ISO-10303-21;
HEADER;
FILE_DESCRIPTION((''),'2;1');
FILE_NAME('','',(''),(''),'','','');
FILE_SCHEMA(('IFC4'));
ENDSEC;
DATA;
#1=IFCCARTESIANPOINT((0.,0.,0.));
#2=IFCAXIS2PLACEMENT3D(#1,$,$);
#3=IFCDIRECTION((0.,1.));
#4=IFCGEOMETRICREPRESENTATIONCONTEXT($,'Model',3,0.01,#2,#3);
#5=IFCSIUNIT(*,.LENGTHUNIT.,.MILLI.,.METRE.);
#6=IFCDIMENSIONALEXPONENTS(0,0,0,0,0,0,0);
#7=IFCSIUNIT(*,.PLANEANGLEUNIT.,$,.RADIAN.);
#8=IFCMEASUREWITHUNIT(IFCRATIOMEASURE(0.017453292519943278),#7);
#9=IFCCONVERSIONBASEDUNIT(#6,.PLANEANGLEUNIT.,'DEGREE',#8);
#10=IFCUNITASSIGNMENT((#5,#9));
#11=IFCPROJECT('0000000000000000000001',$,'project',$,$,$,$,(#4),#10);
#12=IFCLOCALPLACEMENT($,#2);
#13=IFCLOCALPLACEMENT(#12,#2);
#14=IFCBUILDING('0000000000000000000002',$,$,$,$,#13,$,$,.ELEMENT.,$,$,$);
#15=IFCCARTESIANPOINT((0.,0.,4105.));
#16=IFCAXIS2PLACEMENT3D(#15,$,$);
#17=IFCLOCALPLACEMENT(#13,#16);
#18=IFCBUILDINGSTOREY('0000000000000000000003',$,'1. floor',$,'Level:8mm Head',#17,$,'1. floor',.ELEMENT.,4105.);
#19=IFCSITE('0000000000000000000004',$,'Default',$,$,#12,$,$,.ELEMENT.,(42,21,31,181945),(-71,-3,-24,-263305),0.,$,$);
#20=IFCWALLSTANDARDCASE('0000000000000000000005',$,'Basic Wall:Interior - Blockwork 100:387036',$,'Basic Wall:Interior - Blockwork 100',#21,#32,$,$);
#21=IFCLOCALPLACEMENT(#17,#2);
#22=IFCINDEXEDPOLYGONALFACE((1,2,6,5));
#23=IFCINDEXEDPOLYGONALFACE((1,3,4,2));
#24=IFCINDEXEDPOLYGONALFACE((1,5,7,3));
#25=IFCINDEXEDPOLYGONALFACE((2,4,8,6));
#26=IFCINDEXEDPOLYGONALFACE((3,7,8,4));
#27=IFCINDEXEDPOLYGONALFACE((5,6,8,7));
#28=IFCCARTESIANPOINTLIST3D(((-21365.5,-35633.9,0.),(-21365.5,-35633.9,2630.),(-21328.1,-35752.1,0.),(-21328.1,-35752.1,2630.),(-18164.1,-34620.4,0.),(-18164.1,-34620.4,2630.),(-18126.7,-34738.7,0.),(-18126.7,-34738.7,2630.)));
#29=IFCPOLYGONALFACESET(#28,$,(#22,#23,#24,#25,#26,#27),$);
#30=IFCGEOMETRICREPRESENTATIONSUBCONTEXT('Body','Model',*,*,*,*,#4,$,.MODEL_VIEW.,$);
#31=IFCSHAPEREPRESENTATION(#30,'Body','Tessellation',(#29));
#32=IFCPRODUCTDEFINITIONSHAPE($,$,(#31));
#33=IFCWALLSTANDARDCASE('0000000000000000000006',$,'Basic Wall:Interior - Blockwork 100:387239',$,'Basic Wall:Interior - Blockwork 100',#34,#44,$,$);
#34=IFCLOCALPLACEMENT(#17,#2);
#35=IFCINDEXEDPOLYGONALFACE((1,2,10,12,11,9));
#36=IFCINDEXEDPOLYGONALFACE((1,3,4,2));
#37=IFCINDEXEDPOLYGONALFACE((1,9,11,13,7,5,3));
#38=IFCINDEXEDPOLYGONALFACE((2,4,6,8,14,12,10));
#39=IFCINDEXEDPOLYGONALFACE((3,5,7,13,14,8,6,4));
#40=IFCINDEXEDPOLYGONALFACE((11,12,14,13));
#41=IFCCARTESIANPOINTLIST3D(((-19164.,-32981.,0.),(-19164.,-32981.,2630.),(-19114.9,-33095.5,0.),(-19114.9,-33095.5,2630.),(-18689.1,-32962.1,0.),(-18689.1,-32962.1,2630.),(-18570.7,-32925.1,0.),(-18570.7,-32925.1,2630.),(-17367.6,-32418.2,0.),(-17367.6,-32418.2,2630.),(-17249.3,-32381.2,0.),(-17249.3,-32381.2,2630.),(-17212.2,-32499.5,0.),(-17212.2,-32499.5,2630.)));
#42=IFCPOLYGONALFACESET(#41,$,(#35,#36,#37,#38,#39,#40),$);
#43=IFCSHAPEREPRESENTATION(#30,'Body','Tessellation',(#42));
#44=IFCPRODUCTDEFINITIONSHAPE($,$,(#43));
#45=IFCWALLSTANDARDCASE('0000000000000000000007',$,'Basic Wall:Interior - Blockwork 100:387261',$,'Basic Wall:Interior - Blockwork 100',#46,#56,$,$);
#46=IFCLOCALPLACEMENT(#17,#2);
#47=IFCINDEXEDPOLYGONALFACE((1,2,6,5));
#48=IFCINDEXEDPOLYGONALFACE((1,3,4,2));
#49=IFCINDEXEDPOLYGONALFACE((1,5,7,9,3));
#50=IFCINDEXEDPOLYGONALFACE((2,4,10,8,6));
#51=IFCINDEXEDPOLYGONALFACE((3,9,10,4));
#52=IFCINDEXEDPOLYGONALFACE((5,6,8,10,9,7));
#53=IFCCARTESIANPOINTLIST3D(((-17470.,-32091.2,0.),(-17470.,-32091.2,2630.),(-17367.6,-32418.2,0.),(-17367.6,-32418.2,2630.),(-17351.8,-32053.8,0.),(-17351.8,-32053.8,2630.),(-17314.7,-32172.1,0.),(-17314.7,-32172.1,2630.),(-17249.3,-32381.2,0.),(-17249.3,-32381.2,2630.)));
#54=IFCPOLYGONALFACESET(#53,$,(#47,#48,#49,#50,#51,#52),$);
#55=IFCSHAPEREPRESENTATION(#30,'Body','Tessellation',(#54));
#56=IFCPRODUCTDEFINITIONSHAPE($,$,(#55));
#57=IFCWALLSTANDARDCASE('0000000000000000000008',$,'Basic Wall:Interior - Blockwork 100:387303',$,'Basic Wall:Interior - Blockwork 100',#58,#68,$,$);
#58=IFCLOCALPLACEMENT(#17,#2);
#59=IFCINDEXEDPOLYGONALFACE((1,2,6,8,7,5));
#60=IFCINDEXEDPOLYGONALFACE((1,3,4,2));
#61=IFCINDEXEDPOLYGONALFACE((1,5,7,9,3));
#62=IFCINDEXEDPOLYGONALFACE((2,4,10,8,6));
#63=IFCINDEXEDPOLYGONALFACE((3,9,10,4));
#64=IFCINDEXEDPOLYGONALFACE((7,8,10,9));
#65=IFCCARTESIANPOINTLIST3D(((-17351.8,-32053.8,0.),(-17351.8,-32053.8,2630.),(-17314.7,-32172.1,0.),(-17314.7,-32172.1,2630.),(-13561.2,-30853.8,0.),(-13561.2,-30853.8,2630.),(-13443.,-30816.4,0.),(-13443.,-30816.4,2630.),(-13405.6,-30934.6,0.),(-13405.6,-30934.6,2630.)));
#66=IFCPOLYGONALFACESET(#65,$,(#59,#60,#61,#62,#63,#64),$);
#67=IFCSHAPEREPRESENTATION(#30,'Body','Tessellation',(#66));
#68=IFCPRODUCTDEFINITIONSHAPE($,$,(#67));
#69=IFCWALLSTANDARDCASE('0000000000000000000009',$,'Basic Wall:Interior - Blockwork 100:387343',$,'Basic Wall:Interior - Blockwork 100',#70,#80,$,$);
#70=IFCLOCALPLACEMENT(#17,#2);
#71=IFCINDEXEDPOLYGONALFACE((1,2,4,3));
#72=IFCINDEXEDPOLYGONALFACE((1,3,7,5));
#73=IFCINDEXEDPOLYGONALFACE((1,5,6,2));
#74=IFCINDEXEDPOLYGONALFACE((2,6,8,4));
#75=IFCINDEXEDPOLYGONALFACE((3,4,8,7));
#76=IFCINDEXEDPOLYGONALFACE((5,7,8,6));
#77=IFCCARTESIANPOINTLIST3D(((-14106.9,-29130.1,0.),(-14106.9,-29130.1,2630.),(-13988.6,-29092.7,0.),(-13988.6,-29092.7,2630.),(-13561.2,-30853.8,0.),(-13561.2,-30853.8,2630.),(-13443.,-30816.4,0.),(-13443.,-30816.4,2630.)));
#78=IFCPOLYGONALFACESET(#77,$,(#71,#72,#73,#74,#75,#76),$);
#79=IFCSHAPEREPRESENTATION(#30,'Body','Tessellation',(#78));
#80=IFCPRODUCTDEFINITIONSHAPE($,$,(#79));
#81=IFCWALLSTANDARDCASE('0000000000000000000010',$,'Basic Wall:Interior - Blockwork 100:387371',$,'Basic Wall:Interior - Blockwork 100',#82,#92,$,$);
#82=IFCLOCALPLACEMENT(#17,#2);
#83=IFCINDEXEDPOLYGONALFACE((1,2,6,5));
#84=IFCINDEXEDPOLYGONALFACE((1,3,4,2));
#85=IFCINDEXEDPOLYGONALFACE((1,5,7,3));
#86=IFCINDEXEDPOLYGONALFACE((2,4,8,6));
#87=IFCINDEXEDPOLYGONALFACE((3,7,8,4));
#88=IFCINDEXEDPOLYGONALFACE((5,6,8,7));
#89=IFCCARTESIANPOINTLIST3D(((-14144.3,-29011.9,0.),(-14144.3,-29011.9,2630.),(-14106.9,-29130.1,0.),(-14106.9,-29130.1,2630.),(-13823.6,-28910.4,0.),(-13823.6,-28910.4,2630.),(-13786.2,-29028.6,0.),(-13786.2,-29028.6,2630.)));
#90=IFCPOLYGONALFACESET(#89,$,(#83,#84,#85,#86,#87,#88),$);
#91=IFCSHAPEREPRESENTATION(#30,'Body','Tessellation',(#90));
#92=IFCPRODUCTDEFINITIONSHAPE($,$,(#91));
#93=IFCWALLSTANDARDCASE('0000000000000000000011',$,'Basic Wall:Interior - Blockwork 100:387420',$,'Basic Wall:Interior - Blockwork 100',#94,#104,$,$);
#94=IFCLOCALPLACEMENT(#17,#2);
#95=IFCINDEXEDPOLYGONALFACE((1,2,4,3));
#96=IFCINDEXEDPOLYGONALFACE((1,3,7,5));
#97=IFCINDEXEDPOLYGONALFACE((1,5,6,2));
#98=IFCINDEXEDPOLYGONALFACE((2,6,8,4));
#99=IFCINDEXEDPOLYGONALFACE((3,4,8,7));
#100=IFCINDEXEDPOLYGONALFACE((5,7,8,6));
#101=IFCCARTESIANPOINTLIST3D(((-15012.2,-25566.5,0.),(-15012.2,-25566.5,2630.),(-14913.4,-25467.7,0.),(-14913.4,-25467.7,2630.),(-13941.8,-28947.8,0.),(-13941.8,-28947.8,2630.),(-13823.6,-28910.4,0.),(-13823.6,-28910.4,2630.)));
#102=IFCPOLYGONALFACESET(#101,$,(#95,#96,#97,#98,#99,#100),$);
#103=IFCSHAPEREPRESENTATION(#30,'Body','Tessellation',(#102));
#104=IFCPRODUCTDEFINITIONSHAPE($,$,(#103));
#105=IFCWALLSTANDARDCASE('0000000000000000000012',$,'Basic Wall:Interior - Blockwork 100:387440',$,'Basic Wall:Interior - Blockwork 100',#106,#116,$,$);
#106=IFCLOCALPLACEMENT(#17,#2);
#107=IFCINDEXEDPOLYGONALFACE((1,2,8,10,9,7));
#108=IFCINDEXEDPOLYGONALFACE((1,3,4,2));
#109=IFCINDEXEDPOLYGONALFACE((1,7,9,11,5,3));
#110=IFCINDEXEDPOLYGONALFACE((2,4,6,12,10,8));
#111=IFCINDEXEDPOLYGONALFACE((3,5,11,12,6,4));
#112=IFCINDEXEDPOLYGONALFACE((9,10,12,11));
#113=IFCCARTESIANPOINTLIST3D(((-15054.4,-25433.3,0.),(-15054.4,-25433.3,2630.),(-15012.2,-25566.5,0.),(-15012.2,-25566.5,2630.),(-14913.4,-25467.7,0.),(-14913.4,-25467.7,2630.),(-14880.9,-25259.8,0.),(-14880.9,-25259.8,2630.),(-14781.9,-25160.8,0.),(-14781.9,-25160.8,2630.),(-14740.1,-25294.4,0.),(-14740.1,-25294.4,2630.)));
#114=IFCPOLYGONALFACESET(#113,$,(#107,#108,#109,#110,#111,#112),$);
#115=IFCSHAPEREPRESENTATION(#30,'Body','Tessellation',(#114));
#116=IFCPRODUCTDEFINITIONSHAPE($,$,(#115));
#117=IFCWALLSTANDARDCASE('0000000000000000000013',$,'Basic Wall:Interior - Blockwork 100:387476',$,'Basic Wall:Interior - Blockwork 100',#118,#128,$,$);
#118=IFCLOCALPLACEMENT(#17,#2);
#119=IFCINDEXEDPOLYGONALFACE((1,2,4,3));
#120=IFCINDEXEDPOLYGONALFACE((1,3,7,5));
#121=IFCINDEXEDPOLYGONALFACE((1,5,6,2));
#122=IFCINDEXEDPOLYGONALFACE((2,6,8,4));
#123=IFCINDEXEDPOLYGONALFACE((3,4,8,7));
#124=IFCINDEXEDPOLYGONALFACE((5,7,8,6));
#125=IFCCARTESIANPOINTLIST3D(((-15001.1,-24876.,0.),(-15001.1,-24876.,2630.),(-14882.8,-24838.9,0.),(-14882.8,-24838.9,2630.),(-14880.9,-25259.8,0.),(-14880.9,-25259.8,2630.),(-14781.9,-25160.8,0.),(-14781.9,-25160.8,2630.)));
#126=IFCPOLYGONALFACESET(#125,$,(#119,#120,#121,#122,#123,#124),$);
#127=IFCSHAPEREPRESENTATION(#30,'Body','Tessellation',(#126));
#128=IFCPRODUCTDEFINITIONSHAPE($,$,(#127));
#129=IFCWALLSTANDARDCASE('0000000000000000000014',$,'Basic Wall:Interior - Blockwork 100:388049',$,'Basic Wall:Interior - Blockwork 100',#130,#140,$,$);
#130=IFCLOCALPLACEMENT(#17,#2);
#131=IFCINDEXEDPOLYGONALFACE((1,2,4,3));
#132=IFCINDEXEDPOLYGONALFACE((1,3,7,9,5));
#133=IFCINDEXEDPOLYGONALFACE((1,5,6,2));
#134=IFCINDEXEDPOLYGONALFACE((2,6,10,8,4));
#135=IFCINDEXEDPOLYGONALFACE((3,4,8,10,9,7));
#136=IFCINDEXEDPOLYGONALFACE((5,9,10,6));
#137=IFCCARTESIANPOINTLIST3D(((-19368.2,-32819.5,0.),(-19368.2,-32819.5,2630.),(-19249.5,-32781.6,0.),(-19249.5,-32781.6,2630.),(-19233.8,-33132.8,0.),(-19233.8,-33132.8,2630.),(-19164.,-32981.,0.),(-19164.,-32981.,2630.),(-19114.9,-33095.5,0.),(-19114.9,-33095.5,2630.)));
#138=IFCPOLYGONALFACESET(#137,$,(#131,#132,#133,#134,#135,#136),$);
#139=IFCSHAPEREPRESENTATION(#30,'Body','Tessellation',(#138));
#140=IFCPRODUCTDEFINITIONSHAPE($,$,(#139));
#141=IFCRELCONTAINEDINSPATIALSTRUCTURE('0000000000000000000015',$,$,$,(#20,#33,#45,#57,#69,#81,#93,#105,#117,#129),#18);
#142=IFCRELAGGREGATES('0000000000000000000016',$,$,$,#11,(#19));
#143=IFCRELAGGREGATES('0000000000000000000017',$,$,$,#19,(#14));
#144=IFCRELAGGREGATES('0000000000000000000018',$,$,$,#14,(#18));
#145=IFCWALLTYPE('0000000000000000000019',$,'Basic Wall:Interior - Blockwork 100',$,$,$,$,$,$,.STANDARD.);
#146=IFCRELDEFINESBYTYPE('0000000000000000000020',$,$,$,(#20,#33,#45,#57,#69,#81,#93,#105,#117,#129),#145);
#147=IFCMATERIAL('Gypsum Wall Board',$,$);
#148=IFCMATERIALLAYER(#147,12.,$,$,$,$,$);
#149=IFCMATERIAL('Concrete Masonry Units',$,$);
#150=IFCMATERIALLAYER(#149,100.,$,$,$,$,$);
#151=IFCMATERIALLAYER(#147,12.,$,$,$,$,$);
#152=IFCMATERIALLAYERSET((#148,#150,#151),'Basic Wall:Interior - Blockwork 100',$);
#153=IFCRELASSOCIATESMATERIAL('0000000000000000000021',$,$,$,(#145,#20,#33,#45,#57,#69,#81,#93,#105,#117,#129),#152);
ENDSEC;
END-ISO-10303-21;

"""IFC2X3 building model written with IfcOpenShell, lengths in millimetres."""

from ifc_helpers import new_model, entity, si_unit, converted_unit, direction, frame, frame_2d, origin, place, context, subcontext, project, spatial, polyline, rectangle, outline, extrude, material, layer, layer_set, layer_usage, type_object, element, save


model = new_model("IFC2X3")

# Units and contexts
model_context = context("Model", 3, precision=0.01, world=origin(), true_north=direction((0.0, 1.0)))
body_context = subcontext(model_context, "Body", "Model", "MODEL_VIEW")
ifc_project = project(units=[si_unit("LENGTHUNIT", "METRE", prefix="MILLI"), converted_unit("PLANEANGLEUNIT", "DEGREE", entity("IfcRatioMeasure", 0.017453292519943278), si_unit("PLANEANGLEUNIT", "RADIAN"), dimensions=[0, 0, 0, 0, 0, 0, 0])], contexts=[model_context])

# Site, building, storey
site_placement = place(None, origin())
site = spatial("IfcSite", under=ifc_project, at=site_placement, Name="Default", CompositionType="ELEMENT", RefLatitude=(42, 21, 31, 181945), RefLongitude=(-71, -3, -24, -263305), RefElevation=0.0)
building_placement = place(site_placement, origin())
building = spatial("IfcBuilding", under=site, at=building_placement, CompositionType="ELEMENT")
storey_placement = place(building_placement, frame((0.0, 0.0, 4105.0)))
storey = spatial("IfcBuildingStorey", under=building, at=storey_placement, Name="1. floor", ObjectType="Level:8mm Head", LongName="1. floor", CompositionType="ELEMENT", Elevation=4105.0)

# Shared definitions
ifc_material_1 = material(Name="Gypsum Wall Board")

# Walls
ifc_layer_1 = layer(ifc_material_1, 12.0)
ifc_material_2 = material(Name="Concrete Masonry Units")
ifc_layer_2 = layer(ifc_material_2, 100.0)
ifc_layer_3 = layer(ifc_material_1, 12.0)
ifc_layer_set_1 = layer_set([ifc_layer_1, ifc_layer_2, ifc_layer_3], Name="Basic Wall:Interior - Blockwork 100")
wall_type_1 = type_object("IfcWallType", Name="Basic Wall:Interior - Blockwork 100", PredefinedType="STANDARD", material=ifc_layer_set_1)
ifc_layer_usage_1 = layer_usage(ifc_layer_set_1, "AXIS2", "NEGATIVE", 62.0)
wall_1_placement = place(storey_placement, frame((-18145.4, -34679.6, 0.0), z_axis=(0.0, 0.0, 1.0), x_axis=(-0.953372, -0.301797, 0.0)))
element("IfcWallStandardCase", 1, at=wall_1_placement, inside=storey, type_object=wall_type_1, material=ifc_layer_usage_1, Name="Basic Wall:Interior - Blockwork 100:387036", ObjectType="Basic Wall:Interior - Blockwork 100", context=body_context, shape_type="SweptSolid", body=[
    extrude(rectangle(XDim=3358.0, YDim=124.0, at=frame_2d((1679.0, 0.0), x_axis=(-1.0, 0.0))), origin(), (0.0, 0.0, 1.0), 2630.0),
])
ifc_layer_usage_2 = layer_usage(ifc_layer_set_1, "AXIS2", "NEGATIVE", 62.0)
wall_2_placement = place(storey_placement, frame((-19145.5, -33040.1, 0.0), z_axis=(0.0, 0.0, 1.0), x_axis=(0.954277, 0.298924, 0.0)))
element("IfcWallStandardCase", 2, at=wall_2_placement, inside=storey, type_object=wall_type_1, material=ifc_layer_usage_2, Name="Basic Wall:Interior - Blockwork 100:387239", ObjectType="Basic Wall:Interior - Blockwork 100", context=body_context, shape_type="SweptSolid", body=[
    extrude(outline(polyline([(2006.5, -62.0), (2006.5, 62.0), (1882.5, 62.0), (0.0, 62.0), (12.6, -62.0), (458.9, -62.0), (582.9, -62.0), (2006.5, -62.0)])), origin(), (0.0, 0.0, 1.0), 2630.0),
])
ifc_layer_usage_3 = layer_usage(ifc_layer_set_1, "AXIS2", "NEGATIVE", 62.0)
wall_3_placement = place(storey_placement, frame((-17308.4, -32399.7, 0.0), z_axis=(0.0, 0.0, 1.0), x_axis=(-0.298924, 0.954277, 0.0)))
element("IfcWallStandardCase", 3, at=wall_3_placement, inside=storey, type_object=wall_type_1, material=ifc_layer_usage_3, Name="Basic Wall:Interior - Blockwork 100:387261", ObjectType="Basic Wall:Interior - Blockwork 100", context=body_context, shape_type="SweptSolid", body=[
    extrude(outline(polyline([(343.1, -62.0), (342.7, 62.0), (0.0, 62.0), (0.0, -62.0), (219.1, -62.0), (343.1, -62.0)])), origin(), (0.0, 0.0, 1.0), 2630.0),
])
ifc_layer_usage_4 = layer_usage(ifc_layer_set_1, "AXIS2", "NEGATIVE", 62.0)
wall_4_placement = place(storey_placement, frame((-17333.5, -32113.0, 0.0), z_axis=(0.0, 0.0, 1.0), x_axis=(0.953372, 0.301797, 0.0)))
element("IfcWallStandardCase", 4, at=wall_4_placement, inside=storey, type_object=wall_type_1, material=ifc_layer_usage_4, Name="Basic Wall:Interior - Blockwork 100:387303", ObjectType="Basic Wall:Interior - Blockwork 100", context=body_context, shape_type="SweptSolid", body=[
    extrude(outline(polyline([(4100.4, -62.0), (4100.4, 62.0), (3976.4, 62.0), (0.4, 62.0), (0.0, -62.0), (4100.4, -62.0)])), origin(), (0.0, 0.0, 1.0), 2630.0),
])
ifc_layer_usage_5 = layer_usage(ifc_layer_set_1, "AXIS2", "NEGATIVE", 62.0)
wall_5_placement = place(storey_placement, frame((-13502.1, -30835.1, 0.0), z_axis=(0.0, 0.0, 1.0), x_axis=(-0.301797, 0.953372, 0.0)))
element("IfcWallStandardCase", 5, at=wall_5_placement, inside=storey, type_object=wall_type_1, material=ifc_layer_usage_5, Name="Basic Wall:Interior - Blockwork 100:387343", ObjectType="Basic Wall:Interior - Blockwork 100", context=body_context, shape_type="SweptSolid", body=[
    extrude(rectangle(XDim=1808.0, YDim=124.0, at=frame_2d((904.0, 0.0), x_axis=(-1.0, 0.0))), origin(), (0.0, 0.0, 1.0), 2630.0),
])
ifc_layer_usage_6 = layer_usage(ifc_layer_set_1, "AXIS2", "NEGATIVE", 62.0)
wall_6_placement = place(storey_placement, frame((-14125.6, -29071.0, 0.0), z_axis=(0.0, 0.0, 1.0), x_axis=(0.953372, 0.301797, 0.0)))
element("IfcWallStandardCase", 6, at=wall_6_placement, inside=storey, type_object=wall_type_1, material=ifc_layer_usage_6, Name="Basic Wall:Interior - Blockwork 100:387371", ObjectType="Basic Wall:Interior - Blockwork 100", context=body_context, shape_type="SweptSolid", body=[
    extrude(rectangle(XDim=336.4, YDim=124.0, at=frame_2d((168.2, 0.0), x_axis=(-1.0, 0.0))), origin(), (0.0, 0.0, 1.0), 2630.0),
])
ifc_layer_usage_7 = layer_usage(ifc_layer_set_1, "AXIS2", "NEGATIVE", 62.0)
wall_7_placement = place(storey_placement, frame((-13882.7, -28929.1, 0.0), z_axis=(0.0, 0.0, 1.0), x_axis=(-0.301797, 0.953372, 0.0)))
element("IfcWallStandardCase", 7, at=wall_7_placement, inside=storey, type_object=wall_type_1, material=ifc_layer_usage_7, Name="Basic Wall:Interior - Blockwork 100:387420", ObjectType="Basic Wall:Interior - Blockwork 100", context=body_context, shape_type="SweptSolid", body=[
    extrude(outline(polyline([(3611.1, -62.0), (3546.7, 62.0), (0.0, 62.0), (0.0, -62.0), (3611.1, -62.0)])), origin(), (0.0, 0.0, 1.0), 2630.0),
])
ifc_layer_usage_8 = layer_usage(ifc_layer_set_1, "AXIS2", "NEGATIVE", 62.0)
wall_8_placement = place(storey_placement, frame((-15056.0, -25522.6, 0.0), z_axis=(0.0, 0.0, 1.0), x_axis=(0.707107, 0.707107, 0.0)))
element("IfcWallStandardCase", 8, at=wall_8_placement, inside=storey, type_object=wall_type_1, material=ifc_layer_usage_8, Name="Basic Wall:Interior - Blockwork 100:387440", ObjectType="Basic Wall:Interior - Blockwork 100", context=body_context, shape_type="SweptSolid", body=[
    extrude(outline(polyline([(384.8, -62.0), (449.6, 62.0), (309.7, 62.0), (64.4, 62.0), (0.0, -62.0), (139.7, -62.0), (384.8, -62.0)])), origin(), (0.0, 0.0, 1.0), 2630.0),
])
ifc_layer_usage_9 = layer_usage(ifc_layer_set_1, "AXIS2", "NEGATIVE", 62.0)
wall_9_placement = place(storey_placement, frame((-14821.7, -25241.2, 0.0), z_axis=(0.0, 0.0, 1.0), x_axis=(-0.298924, 0.954277, 0.0)))
element("IfcWallStandardCase", 9, at=wall_9_placement, inside=storey, type_object=wall_type_1, material=ifc_layer_usage_9, Name="Basic Wall:Interior - Blockwork 100:387476", ObjectType="Basic Wall:Interior - Blockwork 100", context=body_context, shape_type="SweptSolid", body=[
    extrude(outline(polyline([(402.2, -62.0), (402.2, 62.0), (0.0, 62.0), (64.8, -62.0), (402.2, -62.0)])), origin(), (0.0, 0.0, 1.0), 2630.0),
])
ifc_layer_usage_10 = layer_usage(ifc_layer_set_1, "AXIS2", "NEGATIVE", 62.0)
wall_10_placement = place(storey_placement, frame((-19311.3, -32795.0, 0.0), z_axis=(0.0, 0.0, 1.0), x_axis=(0.394208, -0.919021, 0.0)))
element("IfcWallStandardCase", 10, at=wall_10_placement, inside=storey, type_object=wall_type_1, material=ifc_layer_usage_10, Name="Basic Wall:Interior - Blockwork 100:388049", ObjectType="Basic Wall:Interior - Blockwork 100", context=body_context, shape_type="SweptSolid", body=[
    extrude(outline(polyline([(340.9, -62.0), (353.6, 62.0), (228.9, 62.0), (12.0, 62.0), (0.0, -62.0), (340.9, -62.0)])), origin(), (0.0, 0.0, 1.0), 2630.0),
])

save(model, "model.ifc")
